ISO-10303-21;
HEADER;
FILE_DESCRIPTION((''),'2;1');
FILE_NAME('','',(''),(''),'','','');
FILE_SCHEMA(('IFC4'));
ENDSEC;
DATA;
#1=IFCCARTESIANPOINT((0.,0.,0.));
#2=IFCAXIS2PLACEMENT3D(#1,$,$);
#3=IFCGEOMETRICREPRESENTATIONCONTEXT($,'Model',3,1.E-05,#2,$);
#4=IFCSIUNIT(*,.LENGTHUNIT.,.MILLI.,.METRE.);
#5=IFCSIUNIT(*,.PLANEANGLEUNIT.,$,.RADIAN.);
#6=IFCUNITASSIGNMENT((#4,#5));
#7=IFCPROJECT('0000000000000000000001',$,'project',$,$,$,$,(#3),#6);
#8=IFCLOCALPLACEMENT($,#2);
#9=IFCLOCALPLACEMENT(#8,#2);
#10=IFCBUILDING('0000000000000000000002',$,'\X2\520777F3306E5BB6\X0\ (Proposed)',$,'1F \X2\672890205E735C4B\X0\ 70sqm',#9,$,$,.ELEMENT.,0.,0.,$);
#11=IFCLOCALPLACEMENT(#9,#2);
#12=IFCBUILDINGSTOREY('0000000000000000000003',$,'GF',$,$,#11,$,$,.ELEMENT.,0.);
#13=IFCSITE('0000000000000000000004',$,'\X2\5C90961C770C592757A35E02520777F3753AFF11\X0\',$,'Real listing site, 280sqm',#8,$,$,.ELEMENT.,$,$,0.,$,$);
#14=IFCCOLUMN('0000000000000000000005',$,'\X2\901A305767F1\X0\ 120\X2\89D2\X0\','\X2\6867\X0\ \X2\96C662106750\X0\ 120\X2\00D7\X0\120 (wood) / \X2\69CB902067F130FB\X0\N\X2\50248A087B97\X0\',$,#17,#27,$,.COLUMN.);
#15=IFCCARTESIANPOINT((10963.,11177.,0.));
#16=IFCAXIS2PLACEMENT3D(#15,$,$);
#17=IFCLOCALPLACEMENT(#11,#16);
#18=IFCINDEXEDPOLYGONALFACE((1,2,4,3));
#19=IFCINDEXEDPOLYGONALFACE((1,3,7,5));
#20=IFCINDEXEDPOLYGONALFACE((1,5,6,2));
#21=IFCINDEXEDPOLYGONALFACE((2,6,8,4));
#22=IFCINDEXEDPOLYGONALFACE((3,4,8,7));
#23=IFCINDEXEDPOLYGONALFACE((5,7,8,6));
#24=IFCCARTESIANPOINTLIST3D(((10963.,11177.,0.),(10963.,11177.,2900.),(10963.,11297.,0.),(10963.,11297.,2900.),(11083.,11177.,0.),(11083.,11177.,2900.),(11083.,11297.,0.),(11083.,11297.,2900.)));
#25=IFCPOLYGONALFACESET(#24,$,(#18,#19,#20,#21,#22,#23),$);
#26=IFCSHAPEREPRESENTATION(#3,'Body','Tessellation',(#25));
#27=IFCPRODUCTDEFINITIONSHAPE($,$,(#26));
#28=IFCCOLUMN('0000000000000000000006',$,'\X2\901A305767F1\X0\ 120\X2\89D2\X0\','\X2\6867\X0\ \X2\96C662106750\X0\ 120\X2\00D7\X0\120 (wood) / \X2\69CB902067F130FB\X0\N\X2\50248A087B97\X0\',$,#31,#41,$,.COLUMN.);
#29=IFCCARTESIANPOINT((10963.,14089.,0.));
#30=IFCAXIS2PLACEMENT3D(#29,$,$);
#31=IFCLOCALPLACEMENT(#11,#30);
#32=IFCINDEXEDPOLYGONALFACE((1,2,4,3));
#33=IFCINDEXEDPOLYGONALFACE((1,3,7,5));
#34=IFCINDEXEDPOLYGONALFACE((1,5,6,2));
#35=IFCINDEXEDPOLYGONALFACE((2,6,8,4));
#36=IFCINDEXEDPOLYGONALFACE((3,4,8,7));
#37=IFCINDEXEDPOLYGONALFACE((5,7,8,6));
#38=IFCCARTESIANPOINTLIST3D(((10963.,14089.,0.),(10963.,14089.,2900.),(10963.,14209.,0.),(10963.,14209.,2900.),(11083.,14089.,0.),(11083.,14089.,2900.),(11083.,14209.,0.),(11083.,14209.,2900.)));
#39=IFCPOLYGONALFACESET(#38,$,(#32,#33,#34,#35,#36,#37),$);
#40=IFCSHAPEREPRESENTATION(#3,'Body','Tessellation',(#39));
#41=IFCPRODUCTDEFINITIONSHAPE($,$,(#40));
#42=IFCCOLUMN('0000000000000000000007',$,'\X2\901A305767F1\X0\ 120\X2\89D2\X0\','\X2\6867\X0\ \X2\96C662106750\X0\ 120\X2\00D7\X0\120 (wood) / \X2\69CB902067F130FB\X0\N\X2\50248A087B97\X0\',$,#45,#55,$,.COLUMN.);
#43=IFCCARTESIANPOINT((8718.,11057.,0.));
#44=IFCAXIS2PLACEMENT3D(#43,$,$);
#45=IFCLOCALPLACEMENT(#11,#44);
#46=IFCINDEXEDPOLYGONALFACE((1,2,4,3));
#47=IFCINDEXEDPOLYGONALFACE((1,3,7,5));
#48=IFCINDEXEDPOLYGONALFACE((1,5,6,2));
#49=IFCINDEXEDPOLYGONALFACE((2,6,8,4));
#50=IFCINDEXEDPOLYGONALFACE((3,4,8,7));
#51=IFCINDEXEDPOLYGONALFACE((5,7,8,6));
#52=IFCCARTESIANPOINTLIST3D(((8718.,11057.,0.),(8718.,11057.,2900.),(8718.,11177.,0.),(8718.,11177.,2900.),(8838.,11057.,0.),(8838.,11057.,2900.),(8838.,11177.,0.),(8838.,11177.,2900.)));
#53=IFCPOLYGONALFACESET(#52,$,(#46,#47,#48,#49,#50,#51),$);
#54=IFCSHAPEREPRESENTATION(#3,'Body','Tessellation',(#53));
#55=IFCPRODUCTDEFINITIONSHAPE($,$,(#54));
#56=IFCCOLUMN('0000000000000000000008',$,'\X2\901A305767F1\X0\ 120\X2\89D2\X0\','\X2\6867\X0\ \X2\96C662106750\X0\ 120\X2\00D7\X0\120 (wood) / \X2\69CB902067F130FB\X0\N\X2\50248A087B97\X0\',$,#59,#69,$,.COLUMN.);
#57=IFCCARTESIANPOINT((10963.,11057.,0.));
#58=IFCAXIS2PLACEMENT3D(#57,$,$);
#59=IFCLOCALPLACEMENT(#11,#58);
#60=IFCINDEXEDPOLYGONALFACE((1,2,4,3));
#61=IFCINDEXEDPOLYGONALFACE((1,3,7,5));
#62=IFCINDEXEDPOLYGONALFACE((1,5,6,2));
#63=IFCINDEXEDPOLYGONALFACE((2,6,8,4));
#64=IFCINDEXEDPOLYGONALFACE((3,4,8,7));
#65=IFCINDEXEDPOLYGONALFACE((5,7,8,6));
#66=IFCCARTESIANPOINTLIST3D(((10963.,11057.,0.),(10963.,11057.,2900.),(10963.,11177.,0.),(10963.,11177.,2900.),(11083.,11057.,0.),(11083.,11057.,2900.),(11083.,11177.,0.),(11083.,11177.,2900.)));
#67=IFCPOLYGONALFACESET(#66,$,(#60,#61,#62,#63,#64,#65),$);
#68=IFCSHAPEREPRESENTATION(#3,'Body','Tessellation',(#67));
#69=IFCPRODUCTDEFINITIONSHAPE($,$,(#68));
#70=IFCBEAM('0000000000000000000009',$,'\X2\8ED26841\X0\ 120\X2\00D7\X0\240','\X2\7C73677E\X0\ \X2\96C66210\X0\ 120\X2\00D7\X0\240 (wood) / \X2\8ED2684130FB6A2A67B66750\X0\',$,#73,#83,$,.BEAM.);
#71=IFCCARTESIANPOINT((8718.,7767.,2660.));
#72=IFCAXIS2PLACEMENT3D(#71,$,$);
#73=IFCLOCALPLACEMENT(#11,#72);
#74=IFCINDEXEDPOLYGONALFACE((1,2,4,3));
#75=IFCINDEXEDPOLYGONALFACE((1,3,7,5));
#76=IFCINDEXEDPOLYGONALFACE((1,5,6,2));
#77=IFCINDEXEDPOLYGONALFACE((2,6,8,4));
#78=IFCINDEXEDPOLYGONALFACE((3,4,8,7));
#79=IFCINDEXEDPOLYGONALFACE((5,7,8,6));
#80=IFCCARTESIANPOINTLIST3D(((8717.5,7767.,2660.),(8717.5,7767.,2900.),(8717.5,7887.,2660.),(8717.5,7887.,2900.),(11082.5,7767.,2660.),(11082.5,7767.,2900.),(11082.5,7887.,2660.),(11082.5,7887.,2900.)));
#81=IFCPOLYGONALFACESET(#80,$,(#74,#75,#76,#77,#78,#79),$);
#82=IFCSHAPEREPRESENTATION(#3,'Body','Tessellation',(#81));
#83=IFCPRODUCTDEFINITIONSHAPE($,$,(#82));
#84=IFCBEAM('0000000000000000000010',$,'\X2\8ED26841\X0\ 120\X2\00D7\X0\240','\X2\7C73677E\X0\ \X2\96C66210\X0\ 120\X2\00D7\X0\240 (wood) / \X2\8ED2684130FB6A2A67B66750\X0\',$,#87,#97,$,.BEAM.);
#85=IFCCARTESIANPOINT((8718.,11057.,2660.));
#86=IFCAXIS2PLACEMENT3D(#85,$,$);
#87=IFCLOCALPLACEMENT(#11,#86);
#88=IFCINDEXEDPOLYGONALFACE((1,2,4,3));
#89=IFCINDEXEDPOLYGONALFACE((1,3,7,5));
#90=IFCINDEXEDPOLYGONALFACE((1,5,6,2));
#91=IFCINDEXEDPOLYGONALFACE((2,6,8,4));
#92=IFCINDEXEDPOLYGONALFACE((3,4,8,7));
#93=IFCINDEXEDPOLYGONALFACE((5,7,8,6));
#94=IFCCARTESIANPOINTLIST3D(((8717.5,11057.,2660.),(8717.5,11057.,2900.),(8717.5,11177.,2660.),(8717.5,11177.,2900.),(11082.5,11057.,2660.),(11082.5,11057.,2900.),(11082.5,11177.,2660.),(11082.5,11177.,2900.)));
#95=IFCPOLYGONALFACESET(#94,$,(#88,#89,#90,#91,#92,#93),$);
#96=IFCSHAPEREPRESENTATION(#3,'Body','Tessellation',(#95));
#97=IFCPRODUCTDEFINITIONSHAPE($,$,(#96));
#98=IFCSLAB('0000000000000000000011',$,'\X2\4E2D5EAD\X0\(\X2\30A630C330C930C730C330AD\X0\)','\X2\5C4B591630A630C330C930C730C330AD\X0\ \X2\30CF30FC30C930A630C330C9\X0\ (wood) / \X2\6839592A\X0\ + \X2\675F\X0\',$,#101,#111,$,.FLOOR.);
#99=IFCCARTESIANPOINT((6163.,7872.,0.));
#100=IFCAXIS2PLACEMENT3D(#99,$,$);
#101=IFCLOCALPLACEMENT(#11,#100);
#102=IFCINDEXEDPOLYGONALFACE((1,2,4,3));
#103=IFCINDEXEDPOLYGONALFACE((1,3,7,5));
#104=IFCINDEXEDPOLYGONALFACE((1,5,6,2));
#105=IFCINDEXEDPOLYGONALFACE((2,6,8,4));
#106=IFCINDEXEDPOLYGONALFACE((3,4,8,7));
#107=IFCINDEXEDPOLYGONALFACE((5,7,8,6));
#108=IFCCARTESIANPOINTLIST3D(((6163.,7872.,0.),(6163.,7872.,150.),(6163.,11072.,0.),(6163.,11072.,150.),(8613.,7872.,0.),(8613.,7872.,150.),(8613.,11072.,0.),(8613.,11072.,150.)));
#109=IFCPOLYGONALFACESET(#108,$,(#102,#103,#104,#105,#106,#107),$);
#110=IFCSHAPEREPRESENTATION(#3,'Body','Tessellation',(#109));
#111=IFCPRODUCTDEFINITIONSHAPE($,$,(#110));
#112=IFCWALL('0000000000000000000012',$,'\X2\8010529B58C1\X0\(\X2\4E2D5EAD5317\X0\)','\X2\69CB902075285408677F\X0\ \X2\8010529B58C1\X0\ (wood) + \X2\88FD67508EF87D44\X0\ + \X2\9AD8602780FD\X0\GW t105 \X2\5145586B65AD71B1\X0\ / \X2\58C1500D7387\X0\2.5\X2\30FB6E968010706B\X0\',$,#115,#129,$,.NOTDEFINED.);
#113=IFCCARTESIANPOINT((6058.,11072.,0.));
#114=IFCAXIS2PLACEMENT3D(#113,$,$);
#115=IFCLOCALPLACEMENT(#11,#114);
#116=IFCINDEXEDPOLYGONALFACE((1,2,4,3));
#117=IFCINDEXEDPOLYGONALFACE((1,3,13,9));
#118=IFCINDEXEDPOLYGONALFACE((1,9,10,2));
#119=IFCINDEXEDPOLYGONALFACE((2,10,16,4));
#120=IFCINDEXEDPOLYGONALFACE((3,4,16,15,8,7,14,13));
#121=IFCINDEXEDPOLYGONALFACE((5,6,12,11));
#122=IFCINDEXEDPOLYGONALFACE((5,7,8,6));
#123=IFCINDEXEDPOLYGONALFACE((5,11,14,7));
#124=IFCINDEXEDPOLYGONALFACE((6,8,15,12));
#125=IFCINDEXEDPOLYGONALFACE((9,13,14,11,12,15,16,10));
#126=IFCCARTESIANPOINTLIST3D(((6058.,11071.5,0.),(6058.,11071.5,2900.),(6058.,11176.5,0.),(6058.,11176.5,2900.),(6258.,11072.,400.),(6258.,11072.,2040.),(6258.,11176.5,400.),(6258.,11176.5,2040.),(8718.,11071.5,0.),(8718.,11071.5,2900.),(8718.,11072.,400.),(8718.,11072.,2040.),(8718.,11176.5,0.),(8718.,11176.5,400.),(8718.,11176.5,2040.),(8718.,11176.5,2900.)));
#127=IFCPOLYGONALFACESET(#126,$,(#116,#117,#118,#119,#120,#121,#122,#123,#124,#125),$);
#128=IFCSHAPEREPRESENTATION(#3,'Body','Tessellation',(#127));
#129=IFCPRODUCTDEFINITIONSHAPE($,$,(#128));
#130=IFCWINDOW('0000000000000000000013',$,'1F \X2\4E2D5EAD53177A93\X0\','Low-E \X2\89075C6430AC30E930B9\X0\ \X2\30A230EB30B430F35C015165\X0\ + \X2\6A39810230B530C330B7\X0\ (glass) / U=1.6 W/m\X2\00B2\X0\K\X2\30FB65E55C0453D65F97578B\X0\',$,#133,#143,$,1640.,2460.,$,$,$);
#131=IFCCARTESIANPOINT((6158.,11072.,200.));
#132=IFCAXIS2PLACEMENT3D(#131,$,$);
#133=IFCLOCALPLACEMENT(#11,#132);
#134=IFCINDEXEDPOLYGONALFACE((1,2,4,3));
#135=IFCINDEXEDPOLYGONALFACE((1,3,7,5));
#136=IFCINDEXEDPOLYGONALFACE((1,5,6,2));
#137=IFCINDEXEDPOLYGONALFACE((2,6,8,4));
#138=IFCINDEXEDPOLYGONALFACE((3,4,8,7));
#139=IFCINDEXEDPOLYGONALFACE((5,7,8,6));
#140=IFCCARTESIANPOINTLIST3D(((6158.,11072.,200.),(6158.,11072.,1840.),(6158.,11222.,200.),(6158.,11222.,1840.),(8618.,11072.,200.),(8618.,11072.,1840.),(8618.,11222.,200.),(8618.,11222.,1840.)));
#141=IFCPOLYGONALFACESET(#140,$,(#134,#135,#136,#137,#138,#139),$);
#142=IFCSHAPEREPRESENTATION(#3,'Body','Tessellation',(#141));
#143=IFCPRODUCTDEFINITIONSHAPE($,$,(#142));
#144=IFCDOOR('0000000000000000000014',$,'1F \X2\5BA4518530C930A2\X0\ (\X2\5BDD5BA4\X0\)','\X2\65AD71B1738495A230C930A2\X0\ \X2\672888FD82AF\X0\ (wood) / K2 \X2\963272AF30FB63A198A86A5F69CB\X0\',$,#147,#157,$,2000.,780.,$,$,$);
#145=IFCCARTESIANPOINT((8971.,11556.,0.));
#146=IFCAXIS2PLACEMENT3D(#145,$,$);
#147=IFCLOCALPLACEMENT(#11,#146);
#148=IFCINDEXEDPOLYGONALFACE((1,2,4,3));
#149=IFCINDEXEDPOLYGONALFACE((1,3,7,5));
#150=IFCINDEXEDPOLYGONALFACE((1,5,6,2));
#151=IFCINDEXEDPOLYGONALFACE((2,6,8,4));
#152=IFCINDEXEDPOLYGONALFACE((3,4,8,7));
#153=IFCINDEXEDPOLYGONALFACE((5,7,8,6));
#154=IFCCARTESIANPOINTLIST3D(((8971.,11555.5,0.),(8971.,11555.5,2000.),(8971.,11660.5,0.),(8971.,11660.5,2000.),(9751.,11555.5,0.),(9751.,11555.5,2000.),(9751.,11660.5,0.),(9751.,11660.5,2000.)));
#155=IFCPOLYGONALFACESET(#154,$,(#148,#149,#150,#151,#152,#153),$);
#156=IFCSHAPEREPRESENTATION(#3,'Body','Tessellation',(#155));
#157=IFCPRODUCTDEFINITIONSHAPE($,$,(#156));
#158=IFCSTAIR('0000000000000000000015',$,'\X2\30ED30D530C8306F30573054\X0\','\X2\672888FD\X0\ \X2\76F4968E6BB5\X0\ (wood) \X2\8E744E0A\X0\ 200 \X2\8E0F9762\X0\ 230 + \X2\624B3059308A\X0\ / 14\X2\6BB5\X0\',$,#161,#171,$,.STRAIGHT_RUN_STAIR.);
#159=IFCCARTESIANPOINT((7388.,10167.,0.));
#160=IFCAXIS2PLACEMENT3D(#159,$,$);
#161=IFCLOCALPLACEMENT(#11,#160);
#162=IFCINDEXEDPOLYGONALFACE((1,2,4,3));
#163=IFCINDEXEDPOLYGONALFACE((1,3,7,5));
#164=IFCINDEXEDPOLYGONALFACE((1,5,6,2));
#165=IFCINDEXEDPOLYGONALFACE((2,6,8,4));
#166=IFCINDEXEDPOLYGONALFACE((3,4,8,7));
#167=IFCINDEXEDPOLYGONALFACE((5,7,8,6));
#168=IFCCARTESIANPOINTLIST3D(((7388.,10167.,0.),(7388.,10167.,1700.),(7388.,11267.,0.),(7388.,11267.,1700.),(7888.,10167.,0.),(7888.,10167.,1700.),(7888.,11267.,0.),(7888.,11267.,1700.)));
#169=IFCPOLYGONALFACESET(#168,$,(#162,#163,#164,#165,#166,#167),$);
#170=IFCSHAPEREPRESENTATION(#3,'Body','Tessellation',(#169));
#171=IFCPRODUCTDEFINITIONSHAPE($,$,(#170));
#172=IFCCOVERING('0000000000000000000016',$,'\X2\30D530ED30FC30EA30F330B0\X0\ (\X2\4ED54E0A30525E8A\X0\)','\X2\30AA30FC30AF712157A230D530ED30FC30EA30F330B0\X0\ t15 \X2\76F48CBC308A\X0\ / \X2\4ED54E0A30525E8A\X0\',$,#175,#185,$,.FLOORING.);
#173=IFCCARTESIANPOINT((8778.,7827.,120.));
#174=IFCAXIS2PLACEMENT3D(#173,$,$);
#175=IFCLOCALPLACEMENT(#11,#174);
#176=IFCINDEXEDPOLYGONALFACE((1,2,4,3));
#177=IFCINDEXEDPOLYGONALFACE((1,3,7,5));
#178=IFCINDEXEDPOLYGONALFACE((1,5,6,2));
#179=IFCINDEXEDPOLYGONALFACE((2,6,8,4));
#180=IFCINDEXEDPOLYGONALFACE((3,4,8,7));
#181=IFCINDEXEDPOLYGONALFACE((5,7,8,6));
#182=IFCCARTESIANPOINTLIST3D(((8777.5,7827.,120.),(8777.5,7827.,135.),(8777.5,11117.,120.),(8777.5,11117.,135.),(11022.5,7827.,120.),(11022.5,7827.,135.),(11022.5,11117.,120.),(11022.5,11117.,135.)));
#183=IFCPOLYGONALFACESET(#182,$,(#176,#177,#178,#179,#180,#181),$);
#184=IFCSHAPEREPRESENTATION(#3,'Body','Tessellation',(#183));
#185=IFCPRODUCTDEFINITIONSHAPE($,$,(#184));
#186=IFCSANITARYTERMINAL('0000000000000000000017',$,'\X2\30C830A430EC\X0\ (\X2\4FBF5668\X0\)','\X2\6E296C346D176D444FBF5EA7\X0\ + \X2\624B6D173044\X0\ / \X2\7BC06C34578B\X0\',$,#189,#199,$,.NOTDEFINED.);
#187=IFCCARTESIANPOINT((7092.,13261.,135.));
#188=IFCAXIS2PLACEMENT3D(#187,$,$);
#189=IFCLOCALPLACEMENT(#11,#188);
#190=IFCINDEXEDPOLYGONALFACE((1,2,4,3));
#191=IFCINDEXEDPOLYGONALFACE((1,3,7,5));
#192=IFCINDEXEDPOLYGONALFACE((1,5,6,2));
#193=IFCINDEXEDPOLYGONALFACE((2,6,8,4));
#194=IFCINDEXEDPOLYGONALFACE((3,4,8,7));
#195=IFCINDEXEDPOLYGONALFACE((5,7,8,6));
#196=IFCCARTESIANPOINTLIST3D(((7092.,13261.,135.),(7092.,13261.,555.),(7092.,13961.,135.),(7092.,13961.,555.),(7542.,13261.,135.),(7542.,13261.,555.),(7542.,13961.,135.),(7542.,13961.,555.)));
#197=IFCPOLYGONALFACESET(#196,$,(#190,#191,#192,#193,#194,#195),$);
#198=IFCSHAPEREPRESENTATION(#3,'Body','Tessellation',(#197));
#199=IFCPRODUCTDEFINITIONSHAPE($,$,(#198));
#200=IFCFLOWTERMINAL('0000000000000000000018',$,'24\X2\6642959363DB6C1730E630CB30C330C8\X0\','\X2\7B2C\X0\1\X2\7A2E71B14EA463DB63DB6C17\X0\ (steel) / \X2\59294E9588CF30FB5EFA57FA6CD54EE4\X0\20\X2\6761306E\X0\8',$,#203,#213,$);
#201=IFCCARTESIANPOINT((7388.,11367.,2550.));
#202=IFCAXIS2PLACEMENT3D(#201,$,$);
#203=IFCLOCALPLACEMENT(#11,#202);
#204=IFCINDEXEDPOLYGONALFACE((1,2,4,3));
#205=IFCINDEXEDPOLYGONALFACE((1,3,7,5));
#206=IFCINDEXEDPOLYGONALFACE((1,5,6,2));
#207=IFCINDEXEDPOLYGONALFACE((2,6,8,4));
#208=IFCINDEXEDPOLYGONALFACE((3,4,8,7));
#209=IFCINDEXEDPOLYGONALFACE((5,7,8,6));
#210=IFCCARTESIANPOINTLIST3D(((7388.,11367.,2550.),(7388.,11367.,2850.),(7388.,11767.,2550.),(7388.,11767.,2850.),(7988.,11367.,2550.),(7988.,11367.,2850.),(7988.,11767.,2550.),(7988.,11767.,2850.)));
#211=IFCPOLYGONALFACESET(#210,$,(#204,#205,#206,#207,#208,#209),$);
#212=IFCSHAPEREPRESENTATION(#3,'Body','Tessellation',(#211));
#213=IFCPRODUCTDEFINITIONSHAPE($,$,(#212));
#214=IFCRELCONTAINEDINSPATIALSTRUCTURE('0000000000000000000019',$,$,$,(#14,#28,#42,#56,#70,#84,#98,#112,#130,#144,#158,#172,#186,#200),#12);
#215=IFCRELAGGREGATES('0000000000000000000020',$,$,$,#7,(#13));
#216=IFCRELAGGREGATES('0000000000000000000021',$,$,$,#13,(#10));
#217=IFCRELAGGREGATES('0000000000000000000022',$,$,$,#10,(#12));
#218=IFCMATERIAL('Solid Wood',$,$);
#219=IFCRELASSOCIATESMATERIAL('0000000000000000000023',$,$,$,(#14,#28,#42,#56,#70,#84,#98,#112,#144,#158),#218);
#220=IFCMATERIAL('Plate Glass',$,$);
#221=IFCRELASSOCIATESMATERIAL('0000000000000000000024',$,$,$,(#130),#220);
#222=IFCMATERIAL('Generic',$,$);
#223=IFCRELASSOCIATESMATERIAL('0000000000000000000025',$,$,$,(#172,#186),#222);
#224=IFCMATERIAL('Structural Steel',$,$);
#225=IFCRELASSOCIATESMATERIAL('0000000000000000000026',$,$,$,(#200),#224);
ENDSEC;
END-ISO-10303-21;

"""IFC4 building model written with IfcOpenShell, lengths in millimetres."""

from ifc_helpers import new_model, si_unit, frame, frame_2d, origin, place, context, project, spatial, rectangle, extrude, material, element, fill, save


model = new_model("IFC4")

# Units and contexts
model_context = context("Model", 3, precision=1e-05, world=origin())
ifc_project = project(units=[si_unit("LENGTHUNIT", "METRE", prefix="MILLI"), si_unit("PLANEANGLEUNIT", "RADIAN")], contexts=[model_context])

# Site, building, storey
site_placement = place(None, origin())
site = spatial("IfcSite", under=ifc_project, at=site_placement, Name="岐阜県大垣市切石町１", ObjectType="Real listing site, 280sqm", CompositionType="ELEMENT", RefElevation=0.0)
building_placement = place(site_placement, origin())
building = spatial("IfcBuilding", under=site, at=building_placement, Name="切石の家 (Proposed)", ObjectType="1F 木造平屋 70sqm", CompositionType="ELEMENT", ElevationOfRefHeight=0.0, ElevationOfTerrain=0.0)
storey_placement = place(building_placement, origin())
storey = spatial("IfcBuildingStorey", under=building, at=storey_placement, Name="GF", CompositionType="ELEMENT", Elevation=0.0)

# Columns
ifc_material_1 = material(Name="Solid Wood")
column_1_placement = place(storey_placement, frame((10963.0, 11177.0, 0.0)))
element("IfcColumn", 1, at=column_1_placement, inside=storey, material=ifc_material_1, Name="通し柱 120角", Description="桧 集成材 120×120 (wood) / 構造柱・N値計算", PredefinedType="COLUMN", context=model_context, shape_type="SweptSolid", body=[
    extrude(rectangle(XDim=120.0, YDim=120.0, at=frame_2d((60.0, 60.0))), frame((10963.0, 11177.0, 0.0)), (0.0, 0.0, 1.0), 2900.0),
])
column_2_placement = place(storey_placement, frame((10963.0, 14089.0, 0.0)))
element("IfcColumn", 2, at=column_2_placement, inside=storey, material=ifc_material_1, Name="通し柱 120角", Description="桧 集成材 120×120 (wood) / 構造柱・N値計算", PredefinedType="COLUMN", context=model_context, shape_type="SweptSolid", body=[
    extrude(rectangle(XDim=120.0, YDim=120.0, at=frame_2d((60.0, 60.0))), frame((10963.0, 14089.0, 0.0)), (0.0, 0.0, 1.0), 2900.0),
])
column_3_placement = place(storey_placement, frame((8718.0, 11057.0, 0.0)))
element("IfcColumn", 3, at=column_3_placement, inside=storey, material=ifc_material_1, Name="通し柱 120角", Description="桧 集成材 120×120 (wood) / 構造柱・N値計算", PredefinedType="COLUMN", context=model_context, shape_type="SweptSolid", body=[
    extrude(rectangle(XDim=120.0, YDim=120.0, at=frame_2d((60.0, 60.0))), frame((8718.0, 11057.0, 0.0)), (0.0, 0.0, 1.0), 2900.0),
])
column_4_placement = place(storey_placement, frame((10963.0, 11057.0, 0.0)))
element("IfcColumn", 4, at=column_4_placement, inside=storey, material=ifc_material_1, Name="通し柱 120角", Description="桧 集成材 120×120 (wood) / 構造柱・N値計算", PredefinedType="COLUMN", context=model_context, shape_type="SweptSolid", body=[
    extrude(rectangle(XDim=120.0, YDim=120.0, at=frame_2d((60.0, 60.0))), frame((10963.0, 11057.0, 0.0)), (0.0, 0.0, 1.0), 2900.0),
])

# Beams
beam_1_placement = place(storey_placement, frame((8718.0, 7767.0, 2660.0)))
element("IfcBeam", 5, at=beam_1_placement, inside=storey, material=ifc_material_1, Name="軒桁 120×240", Description="米松 集成 120×240 (wood) / 軒桁・横架材", PredefinedType="BEAM", context=model_context, shape_type="SweptSolid", body=[
    extrude(rectangle(XDim=2365.0, YDim=120.0, at=frame_2d((1182.0, 60.0))), frame((8718.0, 7767.0, 2660.0)), (0.0, 0.0, 1.0), 240.0),
])
beam_2_placement = place(storey_placement, frame((8718.0, 11057.0, 2660.0)))
element("IfcBeam", 6, at=beam_2_placement, inside=storey, material=ifc_material_1, Name="軒桁 120×240", Description="米松 集成 120×240 (wood) / 軒桁・横架材", PredefinedType="BEAM", context=model_context, shape_type="SweptSolid", body=[
    extrude(rectangle(XDim=2365.0, YDim=120.0, at=frame_2d((1182.0, 60.0))), frame((8718.0, 11057.0, 2660.0)), (0.0, 0.0, 1.0), 240.0),
])

# Slab
slab_placement = place(storey_placement, frame((6163.0, 7872.0, 0.0)))
element("IfcSlab", 7, at=slab_placement, inside=storey, material=ifc_material_1, Name="中庭(ウッドデッキ)", Description="屋外ウッドデッキ ハードウッド (wood) / 根太 + 束", PredefinedType="FLOOR", context=model_context, shape_type="SweptSolid", body=[
    extrude(rectangle(XDim=2450.0, YDim=3200.0, at=frame_2d((1225.0, 1600.0))), frame((6163.0, 7872.0, 0.0)), (0.0, 0.0, 1.0), 150.0),
])

# Wall, opening, window
wall_1_placement = place(storey_placement, frame((6058.0, 11072.0, 0.0)))
wall_1 = element("IfcWall", 8, at=wall_1_placement, inside=storey, material=ifc_material_1, Name="耐力壁(中庭北)", Description="構造用合板 耐力壁 (wood) + 製材軸組 + 高性能GW t105 充填断熱 / 壁倍率2.5・準耐火", PredefinedType="NOTDEFINED", context=model_context, shape_type="SweptSolid", body=[
    extrude(rectangle(XDim=2660.0, YDim=105.0, at=frame_2d((1330.0, 52.0))), frame((6058.0, 11072.0, 0.0)), (0.0, 0.0, 1.0), 2900.0),
])
opening_placement = place(storey_placement, frame((6158.0, 11072.0, 200.0)))
opening = element("IfcOpeningElement", 9, at=opening_placement, cuts=wall_1, PredefinedType="NOTDEFINED", context=model_context, shape_type="SweptSolid", body=[
    extrude(rectangle(XDim=2460.0, YDim=150.0, at=frame_2d((1230.0, 75.0))), frame((6158.0, 11072.0, 200.0)), (0.0, 0.0, 1.0), 1640.0),
])
ifc_material_2 = material(Name="Plate Glass")
window_placement = place(storey_placement, frame((6158.0, 11072.0, 200.0)))
window = element("IfcWindow", 10, at=window_placement, inside=storey, material=ifc_material_2, Name="1F 中庭北窓", Description="Low-E 複層ガラス アルゴン封入 + 樹脂サッシ (glass) / U=1.6 W/m²K・日射取得型", OverallHeight=1640.0, OverallWidth=2460.0, context=model_context, shape_type="SweptSolid", body=[
    extrude(rectangle(XDim=2460.0, YDim=150.0, at=frame_2d((1230.0, 75.0))), frame((6158.0, 11072.0, 200.0)), (0.0, 0.0, 1.0), 1640.0),
])
fill(opening, window)

# Door
door_placement = place(storey_placement, frame((8971.0, 11556.0, 0.0)))
element("IfcDoor", 11, at=door_placement, inside=storey, material=ifc_material_1, Name="1F 室内ドア (寝室)", Description="断熱玄関ドア 木製芯 (wood) / K2 防犯・採風機構", OverallHeight=2000.0, OverallWidth=780.0, context=model_context, shape_type="SweptSolid", body=[
    extrude(rectangle(XDim=780.0, YDim=105.0, at=frame_2d((390.0, 52.0))), frame((8971.0, 11556.0, 0.0)), (0.0, 0.0, 1.0), 2000.0),
])

# Stair
stair_placement = place(storey_placement, frame((7388.0, 10167.0, 0.0)))
element("IfcStair", 12, at=stair_placement, inside=storey, material=ifc_material_1, Name="ロフトはしご", Description="木製 直階段 (wood) 蹴上 200 踏面 230 + 手すり / 14段", PredefinedType="STRAIGHT_RUN_STAIR", context=model_context, shape_type="SweptSolid", body=[
    extrude(rectangle(XDim=500.0, YDim=1100.0, at=frame_2d((250.0, 550.0))), frame((7388.0, 10167.0, 0.0)), (0.0, 0.0, 1.0), 1700.0),
])

# Covering
ifc_material_3 = material(Name="Generic")
covering_placement = place(storey_placement, frame((8778.0, 7827.0, 120.0)))
element("IfcCovering", 13, at=covering_placement, inside=storey, material=ifc_material_3, Name="フローリング (仕上げ床)", Description="オーク無垢フローリング t15 直貼り / 仕上げ床", PredefinedType="FLOORING", context=model_context, shape_type="SweptSolid", body=[
    extrude(rectangle(XDim=2245.0, YDim=3290.0, at=frame_2d((1122.0, 1645.0))), frame((8778.0, 7827.0, 120.0)), (0.0, 0.0, 1.0), 15.0),
])

# Sanitary terminal
sanitary_terminal_placement = place(storey_placement, frame((7092.0, 13261.0, 135.0)))
element("IfcSanitaryTerminal", 14, at=sanitary_terminal_placement, inside=storey, material=ifc_material_3, Name="トイレ (便器)", Description="温水洗浄便座 + 手洗い / 節水型", PredefinedType="NOTDEFINED", context=model_context, shape_type="SweptSolid", body=[
    extrude(rectangle(XDim=450.0, YDim=700.0, at=frame_2d((225.0, 350.0))), frame((7092.0, 13261.0, 135.0)), (0.0, 0.0, 1.0), 420.0),
])

# Flow terminal
ifc_material_4 = material(Name="Structural Steel")
flow_terminal_placement = place(storey_placement, frame((7388.0, 11367.0, 2550.0)))
element("IfcFlowTerminal", 15, at=flow_terminal_placement, inside=storey, material=ifc_material_4, Name="24時間換気ユニット", Description="第1種熱交換換気 (steel) / 天井裏・建基法令20条の8", context=model_context, shape_type="SweptSolid", body=[
    extrude(rectangle(XDim=600.0, YDim=400.0, at=frame_2d((300.0, 200.0))), frame((7388.0, 11367.0, 2550.0)), (0.0, 0.0, 1.0), 300.0),
])

save(model, "model.ifc")
